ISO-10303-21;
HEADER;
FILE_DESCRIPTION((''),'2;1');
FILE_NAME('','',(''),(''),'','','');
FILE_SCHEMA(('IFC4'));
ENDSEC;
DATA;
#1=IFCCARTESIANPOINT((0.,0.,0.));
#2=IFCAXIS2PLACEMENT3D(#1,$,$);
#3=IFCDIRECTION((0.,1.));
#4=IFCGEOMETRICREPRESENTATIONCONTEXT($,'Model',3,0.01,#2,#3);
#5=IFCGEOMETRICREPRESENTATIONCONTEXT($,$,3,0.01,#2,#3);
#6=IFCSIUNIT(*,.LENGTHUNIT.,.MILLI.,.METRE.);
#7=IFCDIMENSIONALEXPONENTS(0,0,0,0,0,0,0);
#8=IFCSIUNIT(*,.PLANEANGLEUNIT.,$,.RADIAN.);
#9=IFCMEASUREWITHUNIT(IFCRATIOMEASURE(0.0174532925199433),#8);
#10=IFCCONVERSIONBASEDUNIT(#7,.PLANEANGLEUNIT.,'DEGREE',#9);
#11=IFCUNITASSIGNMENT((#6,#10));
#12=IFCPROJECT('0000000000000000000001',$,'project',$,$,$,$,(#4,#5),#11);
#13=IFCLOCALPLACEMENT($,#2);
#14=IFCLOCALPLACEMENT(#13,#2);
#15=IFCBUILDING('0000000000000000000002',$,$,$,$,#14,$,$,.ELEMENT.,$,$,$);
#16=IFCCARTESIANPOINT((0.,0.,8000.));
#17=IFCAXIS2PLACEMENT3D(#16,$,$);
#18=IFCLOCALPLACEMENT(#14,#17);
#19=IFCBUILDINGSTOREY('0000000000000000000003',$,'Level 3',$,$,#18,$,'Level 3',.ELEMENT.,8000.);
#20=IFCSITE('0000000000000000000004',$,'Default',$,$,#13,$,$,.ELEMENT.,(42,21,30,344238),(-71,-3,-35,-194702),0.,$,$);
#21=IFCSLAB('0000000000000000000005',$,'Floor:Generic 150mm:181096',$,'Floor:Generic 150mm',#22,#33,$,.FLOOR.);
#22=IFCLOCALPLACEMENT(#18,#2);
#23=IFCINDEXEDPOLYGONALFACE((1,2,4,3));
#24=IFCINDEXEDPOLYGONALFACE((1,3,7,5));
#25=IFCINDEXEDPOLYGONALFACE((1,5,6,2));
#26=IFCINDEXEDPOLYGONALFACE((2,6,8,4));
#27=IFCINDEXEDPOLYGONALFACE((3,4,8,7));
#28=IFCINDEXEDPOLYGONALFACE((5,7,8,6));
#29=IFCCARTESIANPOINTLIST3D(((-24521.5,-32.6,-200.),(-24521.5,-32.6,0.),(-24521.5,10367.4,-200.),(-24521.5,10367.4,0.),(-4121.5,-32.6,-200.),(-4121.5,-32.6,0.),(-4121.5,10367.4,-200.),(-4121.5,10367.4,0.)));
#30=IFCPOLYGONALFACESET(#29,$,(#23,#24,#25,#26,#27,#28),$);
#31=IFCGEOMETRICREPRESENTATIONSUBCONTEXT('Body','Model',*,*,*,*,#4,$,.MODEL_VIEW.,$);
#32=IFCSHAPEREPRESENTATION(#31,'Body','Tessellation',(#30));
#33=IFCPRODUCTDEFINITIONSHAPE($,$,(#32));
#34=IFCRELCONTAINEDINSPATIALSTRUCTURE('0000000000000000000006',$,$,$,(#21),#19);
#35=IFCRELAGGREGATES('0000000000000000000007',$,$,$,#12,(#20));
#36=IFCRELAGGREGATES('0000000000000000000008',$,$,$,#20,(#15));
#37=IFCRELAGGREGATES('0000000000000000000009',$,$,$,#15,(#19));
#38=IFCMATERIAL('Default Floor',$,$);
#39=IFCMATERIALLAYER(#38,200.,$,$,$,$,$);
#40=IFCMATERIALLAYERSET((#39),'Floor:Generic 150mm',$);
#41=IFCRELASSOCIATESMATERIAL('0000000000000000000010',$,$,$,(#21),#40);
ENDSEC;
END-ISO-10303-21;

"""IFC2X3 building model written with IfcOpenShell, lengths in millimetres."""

from ifc_helpers import new_model, entity, si_unit, converted_unit, direction, frame, frame_2d, origin, place, context, subcontext, project, spatial, rectangle, extrude, material, layer, layer_set, layer_usage, element, save


model = new_model("IFC2X3")

# Units and contexts
model_context = context("Model", 3, precision=0.01, world=origin(), true_north=direction((0.0, 1.0)))
context_of_model = context(None, 3, precision=0.01, world=origin(), true_north=direction((0.0, 1.0)))
body_context = subcontext(model_context, "Body", "Model", "MODEL_VIEW")
ifc_project = project(units=[si_unit("LENGTHUNIT", "METRE", prefix="MILLI"), converted_unit("PLANEANGLEUNIT", "DEGREE", entity("IfcRatioMeasure", 0.0174532925199433), si_unit("PLANEANGLEUNIT", "RADIAN"), dimensions=[0, 0, 0, 0, 0, 0, 0])], contexts=[model_context, context_of_model])

# Site, building, storey
site_placement = place(None, origin())
site = spatial("IfcSite", under=ifc_project, at=site_placement, Name="Default", CompositionType="ELEMENT", RefLatitude=(42, 21, 30, 344238), RefLongitude=(-71, -3, -35, -194702), RefElevation=0.0)
building_placement = place(site_placement, origin())
building = spatial("IfcBuilding", under=site, at=building_placement, CompositionType="ELEMENT")
storey_placement = place(building_placement, frame((0.0, 0.0, 8000.0)))
storey = spatial("IfcBuildingStorey", under=building, at=storey_placement, Name="Level 3", LongName="Level 3", CompositionType="ELEMENT", Elevation=8000.0)

# Slab
ifc_material = material(Name="Default Floor")
ifc_layer = layer(ifc_material, 200.0)
ifc_layer_set = layer_set([ifc_layer], Name="Floor:Generic 150mm")
ifc_layer_usage = layer_usage(ifc_layer_set, "AXIS3", "POSITIVE", 0.0)
slab_placement = place(storey_placement, origin())
element("IfcSlab", 1, at=slab_placement, inside=storey, material=ifc_layer_usage, Name="Floor:Generic 150mm:181096", ObjectType="Floor:Generic 150mm", PredefinedType="FLOOR", context=body_context, shape_type="SweptSolid", body=[
    extrude(rectangle(XDim=10400.0, YDim=20400.0, at=frame_2d((0.0, 0.0), x_axis=(1.0, 0.0))), frame((-14321.5, 5167.4, 0.0), z_axis=(0.0, 0.0, -1.0), x_axis=(0.0, 1.0, 0.0)), (0.0, 0.0, 1.0), 200.0),
])

save(model, "model.ifc")
